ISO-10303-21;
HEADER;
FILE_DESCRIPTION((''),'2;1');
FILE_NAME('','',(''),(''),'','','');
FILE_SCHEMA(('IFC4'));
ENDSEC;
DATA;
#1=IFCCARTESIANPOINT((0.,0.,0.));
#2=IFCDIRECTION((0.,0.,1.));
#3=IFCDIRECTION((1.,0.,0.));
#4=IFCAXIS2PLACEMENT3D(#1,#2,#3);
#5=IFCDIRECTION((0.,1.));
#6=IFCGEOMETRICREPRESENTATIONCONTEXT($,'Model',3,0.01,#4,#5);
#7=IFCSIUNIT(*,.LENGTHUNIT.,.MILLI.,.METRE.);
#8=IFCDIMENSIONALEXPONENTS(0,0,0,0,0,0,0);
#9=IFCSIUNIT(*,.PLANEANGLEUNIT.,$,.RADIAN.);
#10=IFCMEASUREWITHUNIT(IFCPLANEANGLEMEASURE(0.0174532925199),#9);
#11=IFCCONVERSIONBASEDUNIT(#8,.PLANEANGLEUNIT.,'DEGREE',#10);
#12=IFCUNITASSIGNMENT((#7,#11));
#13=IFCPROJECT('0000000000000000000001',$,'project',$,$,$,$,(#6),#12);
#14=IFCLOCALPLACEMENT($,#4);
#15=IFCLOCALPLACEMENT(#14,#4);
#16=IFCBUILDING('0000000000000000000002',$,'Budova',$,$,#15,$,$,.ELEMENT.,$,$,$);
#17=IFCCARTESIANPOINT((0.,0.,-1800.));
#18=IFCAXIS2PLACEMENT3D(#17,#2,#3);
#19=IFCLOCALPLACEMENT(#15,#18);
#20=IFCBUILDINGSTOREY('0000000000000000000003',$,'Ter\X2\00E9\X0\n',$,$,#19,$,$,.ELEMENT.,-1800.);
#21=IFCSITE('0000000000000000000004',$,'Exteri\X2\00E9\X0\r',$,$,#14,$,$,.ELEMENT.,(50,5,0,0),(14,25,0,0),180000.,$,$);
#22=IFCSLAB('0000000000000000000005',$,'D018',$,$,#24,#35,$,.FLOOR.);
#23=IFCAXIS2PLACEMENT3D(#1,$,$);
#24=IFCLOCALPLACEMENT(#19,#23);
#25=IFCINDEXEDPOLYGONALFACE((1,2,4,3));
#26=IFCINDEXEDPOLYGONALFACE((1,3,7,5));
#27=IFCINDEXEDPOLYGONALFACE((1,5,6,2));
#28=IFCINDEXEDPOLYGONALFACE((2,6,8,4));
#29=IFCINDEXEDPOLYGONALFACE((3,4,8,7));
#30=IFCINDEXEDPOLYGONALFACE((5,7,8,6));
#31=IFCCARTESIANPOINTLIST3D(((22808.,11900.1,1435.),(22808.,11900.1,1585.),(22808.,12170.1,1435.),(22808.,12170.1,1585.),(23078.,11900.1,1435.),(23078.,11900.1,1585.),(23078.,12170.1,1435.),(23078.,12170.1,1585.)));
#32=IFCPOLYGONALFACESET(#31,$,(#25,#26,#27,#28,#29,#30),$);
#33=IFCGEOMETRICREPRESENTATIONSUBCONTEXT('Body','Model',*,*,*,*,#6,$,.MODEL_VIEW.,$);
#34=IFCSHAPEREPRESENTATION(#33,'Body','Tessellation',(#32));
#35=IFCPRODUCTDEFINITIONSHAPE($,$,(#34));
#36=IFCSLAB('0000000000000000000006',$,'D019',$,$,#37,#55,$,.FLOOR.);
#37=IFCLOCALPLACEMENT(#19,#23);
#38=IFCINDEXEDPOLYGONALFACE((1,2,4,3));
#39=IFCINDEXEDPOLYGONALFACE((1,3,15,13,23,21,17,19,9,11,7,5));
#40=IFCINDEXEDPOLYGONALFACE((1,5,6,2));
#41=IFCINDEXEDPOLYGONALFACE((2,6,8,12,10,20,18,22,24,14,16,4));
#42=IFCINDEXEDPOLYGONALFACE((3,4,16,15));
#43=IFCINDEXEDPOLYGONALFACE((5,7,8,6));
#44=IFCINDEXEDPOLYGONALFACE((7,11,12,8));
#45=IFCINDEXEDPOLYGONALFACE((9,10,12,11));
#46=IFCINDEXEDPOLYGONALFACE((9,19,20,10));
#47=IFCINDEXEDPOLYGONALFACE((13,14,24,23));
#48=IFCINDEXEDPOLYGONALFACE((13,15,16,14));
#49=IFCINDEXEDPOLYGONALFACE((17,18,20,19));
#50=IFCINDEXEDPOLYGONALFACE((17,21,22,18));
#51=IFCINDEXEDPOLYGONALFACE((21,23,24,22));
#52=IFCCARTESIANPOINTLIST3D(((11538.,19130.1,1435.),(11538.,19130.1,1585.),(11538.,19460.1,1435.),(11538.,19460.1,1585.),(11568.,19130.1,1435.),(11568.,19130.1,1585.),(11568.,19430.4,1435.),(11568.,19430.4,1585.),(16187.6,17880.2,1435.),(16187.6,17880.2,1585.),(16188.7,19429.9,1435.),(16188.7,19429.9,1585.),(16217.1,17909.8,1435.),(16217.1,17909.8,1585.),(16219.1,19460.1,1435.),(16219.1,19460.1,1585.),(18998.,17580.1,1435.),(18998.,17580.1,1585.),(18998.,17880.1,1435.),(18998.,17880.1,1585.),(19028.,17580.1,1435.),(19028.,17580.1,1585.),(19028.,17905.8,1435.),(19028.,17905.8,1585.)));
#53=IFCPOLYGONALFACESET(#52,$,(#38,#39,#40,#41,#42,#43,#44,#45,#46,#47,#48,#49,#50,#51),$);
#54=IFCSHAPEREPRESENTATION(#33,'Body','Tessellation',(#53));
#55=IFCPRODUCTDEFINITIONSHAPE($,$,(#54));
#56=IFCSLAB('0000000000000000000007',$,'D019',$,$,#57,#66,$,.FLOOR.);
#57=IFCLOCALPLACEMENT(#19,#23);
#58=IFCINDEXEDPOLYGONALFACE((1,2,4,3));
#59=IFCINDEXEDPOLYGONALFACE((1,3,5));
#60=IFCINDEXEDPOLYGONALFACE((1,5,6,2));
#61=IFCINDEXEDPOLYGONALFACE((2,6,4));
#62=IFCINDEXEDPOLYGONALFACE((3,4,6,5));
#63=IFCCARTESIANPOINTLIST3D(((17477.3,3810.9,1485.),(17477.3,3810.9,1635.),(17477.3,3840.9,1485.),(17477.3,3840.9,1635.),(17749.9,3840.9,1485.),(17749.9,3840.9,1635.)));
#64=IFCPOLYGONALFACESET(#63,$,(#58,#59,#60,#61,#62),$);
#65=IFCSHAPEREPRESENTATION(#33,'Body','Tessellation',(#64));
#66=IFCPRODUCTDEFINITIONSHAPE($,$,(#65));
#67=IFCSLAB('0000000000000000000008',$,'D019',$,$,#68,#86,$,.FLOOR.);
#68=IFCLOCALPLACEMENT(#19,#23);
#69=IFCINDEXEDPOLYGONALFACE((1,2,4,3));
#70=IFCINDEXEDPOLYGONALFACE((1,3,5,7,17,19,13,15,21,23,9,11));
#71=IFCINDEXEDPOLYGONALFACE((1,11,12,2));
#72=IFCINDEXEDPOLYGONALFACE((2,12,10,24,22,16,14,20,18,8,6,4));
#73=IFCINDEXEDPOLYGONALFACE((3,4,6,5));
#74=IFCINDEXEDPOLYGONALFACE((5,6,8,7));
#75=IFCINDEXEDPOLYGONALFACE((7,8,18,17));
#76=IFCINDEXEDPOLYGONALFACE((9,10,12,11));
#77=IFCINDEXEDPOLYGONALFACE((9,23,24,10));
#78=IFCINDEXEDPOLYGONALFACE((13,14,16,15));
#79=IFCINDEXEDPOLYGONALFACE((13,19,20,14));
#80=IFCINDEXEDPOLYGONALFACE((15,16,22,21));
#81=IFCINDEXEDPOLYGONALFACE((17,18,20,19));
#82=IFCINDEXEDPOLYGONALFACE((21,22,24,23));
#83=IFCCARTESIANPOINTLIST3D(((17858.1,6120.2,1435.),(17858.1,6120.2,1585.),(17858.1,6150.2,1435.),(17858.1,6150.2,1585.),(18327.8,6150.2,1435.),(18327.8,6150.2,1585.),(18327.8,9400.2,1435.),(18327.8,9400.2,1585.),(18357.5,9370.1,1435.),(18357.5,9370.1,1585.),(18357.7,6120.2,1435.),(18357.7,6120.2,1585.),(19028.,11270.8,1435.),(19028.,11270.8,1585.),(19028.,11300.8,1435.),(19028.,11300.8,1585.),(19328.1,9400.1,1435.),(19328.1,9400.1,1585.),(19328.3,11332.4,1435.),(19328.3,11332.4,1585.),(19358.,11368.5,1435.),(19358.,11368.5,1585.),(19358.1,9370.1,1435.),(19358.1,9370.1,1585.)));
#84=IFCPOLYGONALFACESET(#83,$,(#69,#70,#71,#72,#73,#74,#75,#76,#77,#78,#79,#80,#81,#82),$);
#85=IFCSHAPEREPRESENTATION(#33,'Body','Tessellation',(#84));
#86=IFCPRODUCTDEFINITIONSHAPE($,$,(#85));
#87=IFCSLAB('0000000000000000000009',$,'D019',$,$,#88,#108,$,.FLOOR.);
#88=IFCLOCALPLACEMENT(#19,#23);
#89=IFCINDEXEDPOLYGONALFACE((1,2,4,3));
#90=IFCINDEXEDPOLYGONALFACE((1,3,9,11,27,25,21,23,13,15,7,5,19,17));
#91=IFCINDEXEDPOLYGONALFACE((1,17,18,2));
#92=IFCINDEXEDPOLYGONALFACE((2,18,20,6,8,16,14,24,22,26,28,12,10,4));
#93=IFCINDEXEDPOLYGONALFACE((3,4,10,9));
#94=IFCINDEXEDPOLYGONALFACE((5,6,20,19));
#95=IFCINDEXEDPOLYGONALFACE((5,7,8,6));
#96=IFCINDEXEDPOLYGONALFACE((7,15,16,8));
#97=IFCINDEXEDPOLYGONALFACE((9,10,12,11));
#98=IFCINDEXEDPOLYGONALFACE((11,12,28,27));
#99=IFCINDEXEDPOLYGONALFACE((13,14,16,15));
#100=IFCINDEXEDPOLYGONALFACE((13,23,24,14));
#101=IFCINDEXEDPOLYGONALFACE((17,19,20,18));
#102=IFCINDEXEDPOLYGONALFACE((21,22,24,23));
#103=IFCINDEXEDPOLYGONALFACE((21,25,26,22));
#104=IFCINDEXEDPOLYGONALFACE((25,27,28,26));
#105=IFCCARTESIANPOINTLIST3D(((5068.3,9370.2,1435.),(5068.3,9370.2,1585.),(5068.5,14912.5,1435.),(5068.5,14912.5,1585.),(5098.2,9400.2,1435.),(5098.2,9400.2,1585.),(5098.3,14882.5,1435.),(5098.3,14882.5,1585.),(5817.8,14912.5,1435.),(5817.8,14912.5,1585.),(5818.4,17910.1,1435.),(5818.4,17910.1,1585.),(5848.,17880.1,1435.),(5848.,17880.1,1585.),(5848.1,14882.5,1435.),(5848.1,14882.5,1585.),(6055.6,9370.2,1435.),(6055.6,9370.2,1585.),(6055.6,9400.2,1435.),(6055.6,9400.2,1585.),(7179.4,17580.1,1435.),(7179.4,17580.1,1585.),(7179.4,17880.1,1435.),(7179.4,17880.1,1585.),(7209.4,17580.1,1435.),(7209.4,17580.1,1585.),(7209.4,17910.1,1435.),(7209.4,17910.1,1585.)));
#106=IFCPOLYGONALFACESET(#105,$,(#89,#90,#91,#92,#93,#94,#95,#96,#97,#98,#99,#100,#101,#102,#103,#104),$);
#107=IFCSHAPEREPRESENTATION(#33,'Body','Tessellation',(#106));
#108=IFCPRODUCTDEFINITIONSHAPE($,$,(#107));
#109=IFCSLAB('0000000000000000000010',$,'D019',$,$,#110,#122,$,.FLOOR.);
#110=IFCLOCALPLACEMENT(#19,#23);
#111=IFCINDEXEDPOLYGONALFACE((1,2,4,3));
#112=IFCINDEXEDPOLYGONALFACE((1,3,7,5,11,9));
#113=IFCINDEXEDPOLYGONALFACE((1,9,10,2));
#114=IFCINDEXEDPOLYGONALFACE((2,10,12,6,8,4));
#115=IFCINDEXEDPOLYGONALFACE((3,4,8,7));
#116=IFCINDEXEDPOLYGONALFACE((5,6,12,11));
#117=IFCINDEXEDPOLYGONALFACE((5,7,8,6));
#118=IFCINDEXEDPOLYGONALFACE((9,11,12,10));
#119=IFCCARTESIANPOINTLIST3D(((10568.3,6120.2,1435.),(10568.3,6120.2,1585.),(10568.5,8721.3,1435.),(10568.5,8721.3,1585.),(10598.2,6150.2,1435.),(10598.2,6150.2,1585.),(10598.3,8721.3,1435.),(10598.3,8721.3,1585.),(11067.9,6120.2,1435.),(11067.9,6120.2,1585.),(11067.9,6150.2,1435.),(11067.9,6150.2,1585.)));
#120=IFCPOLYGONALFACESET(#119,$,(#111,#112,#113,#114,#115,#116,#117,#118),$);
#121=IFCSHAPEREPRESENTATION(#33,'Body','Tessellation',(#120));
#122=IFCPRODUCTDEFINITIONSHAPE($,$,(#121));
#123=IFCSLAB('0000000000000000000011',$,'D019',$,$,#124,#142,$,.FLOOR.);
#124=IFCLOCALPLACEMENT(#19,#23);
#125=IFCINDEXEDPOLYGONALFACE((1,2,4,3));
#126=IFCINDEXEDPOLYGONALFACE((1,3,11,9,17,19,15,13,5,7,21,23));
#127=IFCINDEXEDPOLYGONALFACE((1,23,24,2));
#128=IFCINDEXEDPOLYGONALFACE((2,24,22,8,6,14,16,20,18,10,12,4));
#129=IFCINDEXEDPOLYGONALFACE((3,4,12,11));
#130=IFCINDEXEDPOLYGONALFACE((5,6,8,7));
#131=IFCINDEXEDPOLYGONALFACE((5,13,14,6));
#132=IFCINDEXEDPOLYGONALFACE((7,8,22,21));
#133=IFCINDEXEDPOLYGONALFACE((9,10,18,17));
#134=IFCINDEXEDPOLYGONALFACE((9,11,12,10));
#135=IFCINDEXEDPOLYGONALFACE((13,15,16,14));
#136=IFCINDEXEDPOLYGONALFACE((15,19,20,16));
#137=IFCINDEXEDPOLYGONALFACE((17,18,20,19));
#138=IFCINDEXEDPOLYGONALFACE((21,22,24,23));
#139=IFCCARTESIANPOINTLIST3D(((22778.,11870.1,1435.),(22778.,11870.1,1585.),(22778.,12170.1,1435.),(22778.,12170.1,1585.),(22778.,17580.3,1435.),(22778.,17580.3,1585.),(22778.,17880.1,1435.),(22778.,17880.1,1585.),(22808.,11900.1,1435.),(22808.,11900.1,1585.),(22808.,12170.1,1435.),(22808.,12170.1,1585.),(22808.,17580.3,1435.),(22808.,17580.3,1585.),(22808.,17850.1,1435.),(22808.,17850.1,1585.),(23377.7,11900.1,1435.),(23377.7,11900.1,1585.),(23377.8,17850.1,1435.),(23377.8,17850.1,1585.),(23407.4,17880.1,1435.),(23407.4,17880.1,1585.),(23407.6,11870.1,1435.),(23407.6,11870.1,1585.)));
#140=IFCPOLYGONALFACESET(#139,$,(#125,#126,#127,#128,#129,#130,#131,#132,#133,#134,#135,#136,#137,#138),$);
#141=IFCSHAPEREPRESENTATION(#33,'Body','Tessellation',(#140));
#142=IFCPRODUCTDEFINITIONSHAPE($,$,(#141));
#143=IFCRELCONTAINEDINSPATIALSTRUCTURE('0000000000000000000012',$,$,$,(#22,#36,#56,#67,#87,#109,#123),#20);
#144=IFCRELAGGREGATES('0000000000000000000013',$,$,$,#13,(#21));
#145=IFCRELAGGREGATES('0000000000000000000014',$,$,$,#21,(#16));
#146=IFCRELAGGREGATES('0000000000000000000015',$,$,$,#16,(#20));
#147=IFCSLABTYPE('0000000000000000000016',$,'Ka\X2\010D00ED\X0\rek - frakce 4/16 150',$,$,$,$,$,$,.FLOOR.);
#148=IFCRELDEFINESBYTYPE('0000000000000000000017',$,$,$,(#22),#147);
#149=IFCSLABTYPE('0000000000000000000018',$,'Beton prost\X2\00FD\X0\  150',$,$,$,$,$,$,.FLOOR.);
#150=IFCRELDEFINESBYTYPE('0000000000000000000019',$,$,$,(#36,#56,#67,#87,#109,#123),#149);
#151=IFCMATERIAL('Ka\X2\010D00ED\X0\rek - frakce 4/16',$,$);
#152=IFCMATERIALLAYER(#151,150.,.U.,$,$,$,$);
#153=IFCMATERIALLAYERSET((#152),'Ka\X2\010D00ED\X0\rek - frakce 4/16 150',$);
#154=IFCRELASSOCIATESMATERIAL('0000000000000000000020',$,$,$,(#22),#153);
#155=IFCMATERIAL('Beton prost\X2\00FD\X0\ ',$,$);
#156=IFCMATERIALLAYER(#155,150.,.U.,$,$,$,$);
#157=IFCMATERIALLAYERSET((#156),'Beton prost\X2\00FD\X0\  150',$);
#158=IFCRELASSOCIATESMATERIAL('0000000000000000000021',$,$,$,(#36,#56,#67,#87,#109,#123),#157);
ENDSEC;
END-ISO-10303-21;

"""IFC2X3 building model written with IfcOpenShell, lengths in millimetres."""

from ifc_helpers import new_model, entity, si_unit, converted_unit, direction, frame, origin_with_axes, place, context, subcontext, project, spatial, polyline, outline, extrude, material, layer, layer_set, layer_usage, type_object, element, save


model = new_model("IFC2X3")

# Units and contexts
model_context = context("Model", 3, precision=0.01, world=origin_with_axes(), true_north=direction((0.0, 1.0)))
body_context = subcontext(model_context, "Body", "Model", "MODEL_VIEW")
ifc_project = project(units=[si_unit("LENGTHUNIT", "METRE", prefix="MILLI"), converted_unit("PLANEANGLEUNIT", "DEGREE", entity("IfcPlaneAngleMeasure", 0.0174532925199), si_unit("PLANEANGLEUNIT", "RADIAN"), dimensions=[0, 0, 0, 0, 0, 0, 0])], contexts=[model_context])

# Site, building, storey
site_placement = place(None, origin_with_axes())
site = spatial("IfcSite", under=ifc_project, at=site_placement, Name="Exteriér", CompositionType="ELEMENT", RefLatitude=(50, 5, 0, 0), RefLongitude=(14, 25, 0, 0), RefElevation=180000.0)
building_placement = place(site_placement, origin_with_axes())
building = spatial("IfcBuilding", under=site, at=building_placement, Name="Budova", CompositionType="ELEMENT")
storey_placement = place(building_placement, frame((0.0, 0.0, -1800.0), z_axis=(0.0, 0.0, 1.0), x_axis=(1.0, 0.0, 0.0)))
storey = spatial("IfcBuildingStorey", under=building, at=storey_placement, Name="Terén", CompositionType="ELEMENT", Elevation=-1800.0)

# Slabs
ifc_material_1 = material(Name="Beton prostý ")
ifc_material_2 = material(Name="Kačírek - frakce 4/16")
ifc_layer_1 = layer(ifc_material_2, 150.0, ventilated="UNKNOWN")
ifc_layer_set_1 = layer_set([ifc_layer_1], Name="Kačírek - frakce 4/16 150")
slab_type_1 = type_object("IfcSlabType", Name="Kačírek - frakce 4/16 150", PredefinedType="FLOOR")
ifc_layer_usage_1 = layer_usage(ifc_layer_set_1, "AXIS3", "NEGATIVE", 150.0)
slab_1_placement = place(storey_placement, frame((22808.0, 12170.1, 1585.0), z_axis=(0.0, 0.0, 1.0), x_axis=(1.0, 0.0, 0.0)))
element("IfcSlab", 1, at=slab_1_placement, inside=storey, type_object=slab_type_1, material=ifc_layer_usage_1, Name="D018", PredefinedType="FLOOR", context=body_context, shape_type="SweptSolid", body=[
    extrude(outline(polyline([(0.0, 0.0), (0.0, -269.9), (270.0, -269.9), (270.0, 0.1), (0.0, 0.0)])), frame((0.0, 0.0, -150.0), z_axis=(0.0, 0.0, 1.0), x_axis=(1.0, 0.0, 0.0)), (0.0, 0.0, 1.0), 150.0),
])
ifc_layer_2 = layer(ifc_material_1, 150.0, ventilated="UNKNOWN")
ifc_layer_set_2 = layer_set([ifc_layer_2], Name="Beton prostý  150")
ifc_layer_usage_2 = layer_usage(ifc_layer_set_2, "AXIS3", "NEGATIVE", 150.0)
slab_type_2 = type_object("IfcSlabType", Name="Beton prostý  150", PredefinedType="FLOOR")
slab_2_placement = place(storey_placement, frame((11568.0, 19130.1, 1585.0), z_axis=(0.0, 0.0, 1.0), x_axis=(1.0, 0.0, 0.0)))
element("IfcSlab", 2, at=slab_2_placement, inside=storey, type_object=slab_type_2, material=ifc_layer_usage_2, Name="D019", PredefinedType="FLOOR", context=body_context, shape_type="SweptSolid", body=[
    extrude(outline(polyline([(0.0, 0.0), (0.0, 300.3), (4620.7, 299.8), (4619.6, -1250.0), (7430.0, -1250.0), (7430.0, -1550.0), (7460.0, -1550.0), (7460.0, -1224.3), (4649.1, -1220.3), (4651.0, 330.0), (-30.0, 330.0), (-30.0, 0.0), (0.0, 0.0)])), frame((0.0, 0.0, -150.0), z_axis=(0.0, 0.0, 1.0), x_axis=(1.0, 0.0, 0.0)), (0.0, 0.0, 1.0), 150.0),
])
ifc_layer_usage_3 = layer_usage(ifc_layer_set_2, "AXIS3", "NEGATIVE", 150.0)
slab_3_placement = place(storey_placement, frame((17477.3, 3810.9, 1635.0), z_axis=(0.0, 0.0, 1.0), x_axis=(1.0, 0.0, 0.0)))
element("IfcSlab", 3, at=slab_3_placement, inside=storey, type_object=slab_type_2, material=ifc_layer_usage_3, Name="D019", PredefinedType="FLOOR", context=body_context, shape_type="SweptSolid", body=[
    extrude(outline(polyline([(0.0, 0.0), (272.6, 30.0), (0.0, 30.0), (0.0, 0.0)])), frame((0.0, 0.0, -150.0), z_axis=(0.0, 0.0, 1.0), x_axis=(1.0, 0.0, 0.0)), (0.0, 0.0, 1.0), 150.0),
])
ifc_layer_usage_4 = layer_usage(ifc_layer_set_2, "AXIS3", "NEGATIVE", 150.0)
slab_4_placement = place(storey_placement, frame((17858.1, 6150.2, 1585.0), z_axis=(0.0, 0.0, 1.0), x_axis=(1.0, 0.0, 0.0)))
element("IfcSlab", 4, at=slab_4_placement, inside=storey, type_object=slab_type_2, material=ifc_layer_usage_4, Name="D019", PredefinedType="FLOOR", context=body_context, shape_type="SweptSolid", body=[
    extrude(outline(polyline([(0.0, 0.0), (0.0, -30.0), (499.6, -30.0), (499.5, 3219.9), (1500.0, 3219.9), (1499.9, 5218.3), (1169.9, 5150.6), (1169.9, 5120.6), (1470.2, 5182.2), (1470.0, 3249.9), (469.7, 3250.0), (469.7, 0.0), (0.0, 0.0)])), frame((0.0, 0.0, -150.0), z_axis=(0.0, 0.0, 1.0), x_axis=(1.0, 0.0, 0.0)), (0.0, 0.0, 1.0), 150.0),
])
ifc_layer_usage_5 = layer_usage(ifc_layer_set_2, "AXIS3", "NEGATIVE", 150.0)
slab_5_placement = place(storey_placement, frame((5068.4, 9400.2, 1585.0), z_axis=(0.0, 0.0, 1.0), x_axis=(1.0, 0.0, 0.0)))
element("IfcSlab", 5, at=slab_5_placement, inside=storey, type_object=slab_type_2, material=ifc_layer_usage_5, Name="D019", PredefinedType="FLOOR", context=body_context, shape_type="SweptSolid", body=[
    extrude(outline(polyline([(0.0, -30.0), (987.3, -30.0), (987.3, 0.0), (29.9, 0.0), (29.9, 5482.3), (779.7, 5482.3), (779.7, 8479.9), (2111.0, 8479.9), (2111.0, 8179.9), (2141.0, 8179.9), (2141.0, 8509.9), (750.1, 8509.9), (749.5, 5512.3), (0.1, 5512.3), (0.0, -30.0)])), frame((0.0, 0.0, -150.0), z_axis=(0.0, 0.0, 1.0), x_axis=(1.0, 0.0, 0.0)), (0.0, 0.0, 1.0), 150.0),
])
ifc_layer_usage_6 = layer_usage(ifc_layer_set_2, "AXIS3", "NEGATIVE", 150.0)
slab_6_placement = place(storey_placement, frame((10568.4, 6150.2, 1585.0), z_axis=(0.0, 0.0, 1.0), x_axis=(1.0, 0.0, 0.0)))
element("IfcSlab", 6, at=slab_6_placement, inside=storey, type_object=slab_type_2, material=ifc_layer_usage_6, Name="D019", PredefinedType="FLOOR", context=body_context, shape_type="SweptSolid", body=[
    extrude(outline(polyline([(0.0, -30.0), (499.6, -30.0), (499.6, 0.0), (29.9, 0.0), (29.9, 2571.1), (0.1, 2571.1), (0.0, -30.0)])), frame((0.0, 0.0, -150.0), z_axis=(0.0, 0.0, 1.0), x_axis=(1.0, 0.0, 0.0)), (0.0, 0.0, 1.0), 150.0),
])
ifc_layer_usage_7 = layer_usage(ifc_layer_set_2, "AXIS3", "NEGATIVE", 150.0)
slab_7_placement = place(storey_placement, frame((22808.0, 12170.1, 1585.0), z_axis=(0.0, 0.0, 1.0), x_axis=(1.0, 0.0, 0.0)))
element("IfcSlab", 7, at=slab_7_placement, inside=storey, type_object=slab_type_2, material=ifc_layer_usage_7, Name="D019", PredefinedType="FLOOR", context=body_context, shape_type="SweptSolid", body=[
    extrude(outline(polyline([(0.0, 0.0), (-30.0, 0.0), (-30.0, -300.0), (599.6, -299.9), (599.4, 5710.1), (-30.0, 5710.0), (-30.0, 5410.3), (0.0, 5410.3), (0.0, 5680.1), (569.8, 5680.1), (569.7, -269.9), (0.0, -269.9), (0.0, 0.0)])), frame((0.0, 0.0, -150.0), z_axis=(0.0, 0.0, 1.0), x_axis=(1.0, 0.0, 0.0)), (0.0, 0.0, 1.0), 150.0),
])

save(model, "model.ifc")
